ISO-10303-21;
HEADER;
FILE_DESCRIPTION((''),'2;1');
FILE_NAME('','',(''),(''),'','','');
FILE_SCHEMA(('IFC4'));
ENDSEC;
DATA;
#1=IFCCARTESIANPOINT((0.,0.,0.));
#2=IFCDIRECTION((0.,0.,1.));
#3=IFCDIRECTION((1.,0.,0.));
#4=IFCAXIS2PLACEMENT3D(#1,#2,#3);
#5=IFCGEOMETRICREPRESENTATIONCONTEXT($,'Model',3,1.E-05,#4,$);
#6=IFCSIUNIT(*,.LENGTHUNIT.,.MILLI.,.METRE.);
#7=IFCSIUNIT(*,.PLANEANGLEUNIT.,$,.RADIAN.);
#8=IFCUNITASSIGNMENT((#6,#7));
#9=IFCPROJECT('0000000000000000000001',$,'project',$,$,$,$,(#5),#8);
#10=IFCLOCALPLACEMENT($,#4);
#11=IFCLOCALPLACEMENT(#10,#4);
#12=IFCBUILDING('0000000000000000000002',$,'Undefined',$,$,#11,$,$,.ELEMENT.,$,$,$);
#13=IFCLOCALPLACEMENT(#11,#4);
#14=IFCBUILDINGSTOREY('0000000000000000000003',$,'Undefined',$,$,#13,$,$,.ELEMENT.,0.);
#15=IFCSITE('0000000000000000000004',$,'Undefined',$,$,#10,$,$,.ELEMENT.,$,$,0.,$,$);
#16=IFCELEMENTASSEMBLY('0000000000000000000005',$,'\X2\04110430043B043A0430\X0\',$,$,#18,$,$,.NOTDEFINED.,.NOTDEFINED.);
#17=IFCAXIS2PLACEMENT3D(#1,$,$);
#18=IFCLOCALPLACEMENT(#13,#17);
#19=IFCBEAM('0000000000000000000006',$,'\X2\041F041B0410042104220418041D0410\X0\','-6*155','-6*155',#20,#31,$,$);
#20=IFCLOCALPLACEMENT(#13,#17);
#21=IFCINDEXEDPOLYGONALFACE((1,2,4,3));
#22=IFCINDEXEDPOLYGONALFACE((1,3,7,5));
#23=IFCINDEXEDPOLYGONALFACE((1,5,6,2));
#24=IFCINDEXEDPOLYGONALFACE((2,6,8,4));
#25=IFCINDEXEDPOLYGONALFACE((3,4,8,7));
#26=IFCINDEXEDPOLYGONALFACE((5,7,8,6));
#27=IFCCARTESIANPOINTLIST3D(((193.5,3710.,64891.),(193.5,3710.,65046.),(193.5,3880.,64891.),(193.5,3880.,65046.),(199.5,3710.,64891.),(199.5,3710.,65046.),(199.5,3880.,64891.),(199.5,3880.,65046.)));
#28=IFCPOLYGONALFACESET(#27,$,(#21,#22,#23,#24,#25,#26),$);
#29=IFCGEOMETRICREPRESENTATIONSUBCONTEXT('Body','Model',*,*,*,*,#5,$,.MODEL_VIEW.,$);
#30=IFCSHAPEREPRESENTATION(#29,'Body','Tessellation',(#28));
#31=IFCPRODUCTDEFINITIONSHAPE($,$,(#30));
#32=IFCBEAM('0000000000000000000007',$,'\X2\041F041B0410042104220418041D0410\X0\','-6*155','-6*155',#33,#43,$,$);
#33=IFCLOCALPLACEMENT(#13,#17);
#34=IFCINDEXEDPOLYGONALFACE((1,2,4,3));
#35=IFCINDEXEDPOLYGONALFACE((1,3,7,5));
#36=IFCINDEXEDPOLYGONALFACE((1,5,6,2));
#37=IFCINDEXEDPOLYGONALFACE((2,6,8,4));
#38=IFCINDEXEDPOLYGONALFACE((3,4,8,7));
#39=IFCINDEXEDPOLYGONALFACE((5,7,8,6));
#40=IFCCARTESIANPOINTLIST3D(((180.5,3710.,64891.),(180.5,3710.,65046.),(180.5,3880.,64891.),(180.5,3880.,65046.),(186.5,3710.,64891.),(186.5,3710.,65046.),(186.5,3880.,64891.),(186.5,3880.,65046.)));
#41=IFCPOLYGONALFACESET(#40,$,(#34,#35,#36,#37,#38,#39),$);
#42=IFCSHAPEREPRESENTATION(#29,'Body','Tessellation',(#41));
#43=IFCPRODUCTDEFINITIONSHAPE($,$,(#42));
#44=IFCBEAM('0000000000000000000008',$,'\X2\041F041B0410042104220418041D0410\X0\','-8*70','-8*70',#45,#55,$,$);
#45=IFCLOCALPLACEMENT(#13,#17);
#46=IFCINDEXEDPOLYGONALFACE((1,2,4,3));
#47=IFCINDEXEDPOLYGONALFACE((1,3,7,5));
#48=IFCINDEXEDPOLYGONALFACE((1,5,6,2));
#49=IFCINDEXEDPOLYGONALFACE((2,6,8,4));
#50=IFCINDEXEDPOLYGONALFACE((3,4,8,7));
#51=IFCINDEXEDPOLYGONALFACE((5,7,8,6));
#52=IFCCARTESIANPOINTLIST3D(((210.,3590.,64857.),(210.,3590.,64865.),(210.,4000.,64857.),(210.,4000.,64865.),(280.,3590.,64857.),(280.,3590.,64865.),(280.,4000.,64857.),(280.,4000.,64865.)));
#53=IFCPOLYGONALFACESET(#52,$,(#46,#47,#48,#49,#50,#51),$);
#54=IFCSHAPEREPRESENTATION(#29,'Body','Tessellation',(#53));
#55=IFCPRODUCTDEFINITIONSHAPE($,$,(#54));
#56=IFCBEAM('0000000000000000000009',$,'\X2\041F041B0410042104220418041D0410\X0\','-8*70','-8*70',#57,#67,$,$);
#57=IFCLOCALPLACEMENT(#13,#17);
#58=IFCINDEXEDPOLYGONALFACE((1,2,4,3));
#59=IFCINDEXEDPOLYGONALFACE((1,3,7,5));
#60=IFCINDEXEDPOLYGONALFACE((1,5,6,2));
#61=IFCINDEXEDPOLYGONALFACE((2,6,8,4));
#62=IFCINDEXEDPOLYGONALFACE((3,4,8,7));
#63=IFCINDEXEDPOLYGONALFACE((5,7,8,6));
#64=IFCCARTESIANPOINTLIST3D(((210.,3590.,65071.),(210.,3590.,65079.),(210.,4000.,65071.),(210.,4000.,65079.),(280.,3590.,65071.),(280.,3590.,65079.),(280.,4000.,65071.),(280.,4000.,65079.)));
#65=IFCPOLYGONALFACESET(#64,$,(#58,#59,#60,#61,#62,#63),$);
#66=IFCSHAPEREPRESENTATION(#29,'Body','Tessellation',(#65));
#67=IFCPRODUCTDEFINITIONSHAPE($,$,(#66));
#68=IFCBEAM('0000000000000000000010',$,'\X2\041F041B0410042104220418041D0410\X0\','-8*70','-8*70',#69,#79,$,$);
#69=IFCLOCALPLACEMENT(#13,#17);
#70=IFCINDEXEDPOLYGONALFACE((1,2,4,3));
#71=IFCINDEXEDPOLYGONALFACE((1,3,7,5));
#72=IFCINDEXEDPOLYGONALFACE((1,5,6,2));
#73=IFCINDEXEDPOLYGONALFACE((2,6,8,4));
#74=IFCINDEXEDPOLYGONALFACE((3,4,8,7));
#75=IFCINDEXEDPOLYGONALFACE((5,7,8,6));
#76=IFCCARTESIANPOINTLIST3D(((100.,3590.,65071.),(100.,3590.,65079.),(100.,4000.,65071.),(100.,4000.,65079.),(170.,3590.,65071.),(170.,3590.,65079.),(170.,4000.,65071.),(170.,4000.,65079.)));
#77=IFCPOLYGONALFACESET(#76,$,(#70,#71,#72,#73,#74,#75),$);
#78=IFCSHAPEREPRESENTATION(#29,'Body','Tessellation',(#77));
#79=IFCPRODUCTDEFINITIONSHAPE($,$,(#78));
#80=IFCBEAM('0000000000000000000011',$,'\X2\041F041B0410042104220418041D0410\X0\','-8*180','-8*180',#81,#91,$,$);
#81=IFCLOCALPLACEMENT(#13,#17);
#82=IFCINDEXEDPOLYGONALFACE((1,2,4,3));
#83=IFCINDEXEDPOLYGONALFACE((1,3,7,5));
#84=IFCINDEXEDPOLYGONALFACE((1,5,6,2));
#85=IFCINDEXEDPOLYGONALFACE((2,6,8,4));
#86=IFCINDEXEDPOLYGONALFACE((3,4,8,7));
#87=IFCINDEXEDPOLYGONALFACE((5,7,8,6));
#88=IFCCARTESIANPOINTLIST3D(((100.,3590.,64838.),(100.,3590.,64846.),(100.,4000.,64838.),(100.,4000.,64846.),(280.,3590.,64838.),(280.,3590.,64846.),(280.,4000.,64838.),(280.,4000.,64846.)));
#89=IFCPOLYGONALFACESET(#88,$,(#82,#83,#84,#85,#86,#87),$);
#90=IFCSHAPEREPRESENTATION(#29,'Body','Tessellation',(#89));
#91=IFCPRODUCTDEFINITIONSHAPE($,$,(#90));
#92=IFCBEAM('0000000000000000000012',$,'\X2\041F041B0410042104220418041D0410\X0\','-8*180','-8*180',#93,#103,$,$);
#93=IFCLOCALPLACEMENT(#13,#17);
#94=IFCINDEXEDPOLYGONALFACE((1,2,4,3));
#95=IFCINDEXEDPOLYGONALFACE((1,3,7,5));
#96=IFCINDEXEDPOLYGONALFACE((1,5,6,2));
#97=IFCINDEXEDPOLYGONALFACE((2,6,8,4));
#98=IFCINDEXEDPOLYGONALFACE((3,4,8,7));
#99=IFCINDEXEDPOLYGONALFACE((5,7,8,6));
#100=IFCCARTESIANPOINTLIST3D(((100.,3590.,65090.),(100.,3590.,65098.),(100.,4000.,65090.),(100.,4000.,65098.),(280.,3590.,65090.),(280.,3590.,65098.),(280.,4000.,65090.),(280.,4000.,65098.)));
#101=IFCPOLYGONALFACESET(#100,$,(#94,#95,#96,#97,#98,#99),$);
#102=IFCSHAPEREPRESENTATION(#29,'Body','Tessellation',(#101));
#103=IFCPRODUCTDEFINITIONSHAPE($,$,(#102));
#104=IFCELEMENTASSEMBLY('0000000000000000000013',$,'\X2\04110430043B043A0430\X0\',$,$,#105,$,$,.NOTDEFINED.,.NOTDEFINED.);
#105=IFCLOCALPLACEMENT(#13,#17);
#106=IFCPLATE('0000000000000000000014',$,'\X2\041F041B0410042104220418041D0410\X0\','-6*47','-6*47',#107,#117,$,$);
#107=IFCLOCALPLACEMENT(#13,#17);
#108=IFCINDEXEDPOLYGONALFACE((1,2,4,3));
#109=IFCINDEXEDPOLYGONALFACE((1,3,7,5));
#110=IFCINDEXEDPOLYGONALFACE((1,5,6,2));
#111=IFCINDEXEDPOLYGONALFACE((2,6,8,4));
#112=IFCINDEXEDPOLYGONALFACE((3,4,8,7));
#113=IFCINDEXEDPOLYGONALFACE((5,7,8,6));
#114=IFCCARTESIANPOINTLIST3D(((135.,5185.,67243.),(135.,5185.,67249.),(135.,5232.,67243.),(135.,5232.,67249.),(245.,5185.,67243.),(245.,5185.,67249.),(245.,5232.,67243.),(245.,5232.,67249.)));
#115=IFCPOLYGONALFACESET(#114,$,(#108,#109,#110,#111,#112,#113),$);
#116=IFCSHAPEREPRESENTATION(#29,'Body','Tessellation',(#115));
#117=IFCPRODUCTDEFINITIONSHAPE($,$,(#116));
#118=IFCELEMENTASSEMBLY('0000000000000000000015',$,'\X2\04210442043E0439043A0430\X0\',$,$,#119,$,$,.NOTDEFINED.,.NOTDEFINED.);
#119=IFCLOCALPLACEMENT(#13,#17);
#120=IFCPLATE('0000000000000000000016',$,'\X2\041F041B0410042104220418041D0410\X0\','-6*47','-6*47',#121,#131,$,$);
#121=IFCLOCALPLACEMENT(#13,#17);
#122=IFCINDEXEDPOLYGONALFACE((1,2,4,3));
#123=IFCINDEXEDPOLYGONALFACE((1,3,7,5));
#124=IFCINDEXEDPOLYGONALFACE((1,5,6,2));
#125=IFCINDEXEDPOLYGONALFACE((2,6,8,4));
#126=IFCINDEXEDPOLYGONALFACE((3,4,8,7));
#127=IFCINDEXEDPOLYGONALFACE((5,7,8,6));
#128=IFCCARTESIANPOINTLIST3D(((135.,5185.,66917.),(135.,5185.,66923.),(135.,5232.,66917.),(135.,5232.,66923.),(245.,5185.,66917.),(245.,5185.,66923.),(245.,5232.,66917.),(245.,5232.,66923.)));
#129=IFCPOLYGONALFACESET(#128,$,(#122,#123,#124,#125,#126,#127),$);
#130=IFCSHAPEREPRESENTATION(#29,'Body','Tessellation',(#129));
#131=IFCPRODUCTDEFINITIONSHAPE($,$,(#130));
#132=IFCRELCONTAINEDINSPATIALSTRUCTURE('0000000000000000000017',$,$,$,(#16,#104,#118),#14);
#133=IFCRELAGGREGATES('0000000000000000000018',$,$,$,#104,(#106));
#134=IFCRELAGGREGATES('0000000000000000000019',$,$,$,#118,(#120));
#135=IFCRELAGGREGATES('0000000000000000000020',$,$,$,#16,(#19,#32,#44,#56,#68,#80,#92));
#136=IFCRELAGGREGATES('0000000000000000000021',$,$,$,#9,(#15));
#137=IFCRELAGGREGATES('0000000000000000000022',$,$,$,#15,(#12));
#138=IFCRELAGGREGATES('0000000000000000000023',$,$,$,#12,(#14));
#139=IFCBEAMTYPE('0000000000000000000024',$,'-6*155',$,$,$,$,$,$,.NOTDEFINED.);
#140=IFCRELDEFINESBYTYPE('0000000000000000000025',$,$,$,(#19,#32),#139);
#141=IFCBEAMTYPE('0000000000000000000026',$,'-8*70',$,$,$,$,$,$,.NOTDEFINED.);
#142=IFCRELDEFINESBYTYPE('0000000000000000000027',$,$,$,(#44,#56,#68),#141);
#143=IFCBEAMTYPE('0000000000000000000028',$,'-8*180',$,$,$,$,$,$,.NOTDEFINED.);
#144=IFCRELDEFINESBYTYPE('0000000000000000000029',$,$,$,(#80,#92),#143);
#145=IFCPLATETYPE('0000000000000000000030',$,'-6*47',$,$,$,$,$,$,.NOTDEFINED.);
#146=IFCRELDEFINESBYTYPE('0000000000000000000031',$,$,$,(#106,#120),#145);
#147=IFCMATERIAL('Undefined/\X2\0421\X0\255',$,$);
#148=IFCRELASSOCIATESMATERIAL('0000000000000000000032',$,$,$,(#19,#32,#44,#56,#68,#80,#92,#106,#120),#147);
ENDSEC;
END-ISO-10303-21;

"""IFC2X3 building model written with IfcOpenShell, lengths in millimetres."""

from ifc_helpers import new_model, si_unit, frame, origin_with_axes, origin_2d_with_axis, place, context, subcontext, project, spatial, polyline, rectangle, outline, extrude, boolean, material, type_object, element, aggregate, save


model = new_model("IFC2X3")

# Units and contexts
model_context = context("Model", 3, precision=1e-05, world=origin_with_axes())
body_context = subcontext(model_context, "Body", "Model", "MODEL_VIEW")
ifc_project = project(units=[si_unit("LENGTHUNIT", "METRE", prefix="MILLI"), si_unit("PLANEANGLEUNIT", "RADIAN")], contexts=[model_context])

# Site, building, storey
site_placement = place(None, origin_with_axes())
site = spatial("IfcSite", under=ifc_project, at=site_placement, Name="Undefined", CompositionType="ELEMENT", RefElevation=0.0)
building_placement = place(site_placement, origin_with_axes())
building = spatial("IfcBuilding", under=site, at=building_placement, Name="Undefined", CompositionType="ELEMENT")
storey_placement = place(building_placement, origin_with_axes())
storey = spatial("IfcBuildingStorey", under=building, at=storey_placement, Name="Undefined", CompositionType="ELEMENT", Elevation=0.0)

# Element assembly, beams
assembly_1_placement = place(storey_placement, origin_with_axes())
assembly_1 = element("IfcElementAssembly", 1, at=assembly_1_placement, inside=storey, Name="Балка", AssemblyPlace="NOTDEFINED", PredefinedType="NOTDEFINED")
ifc_material_1 = material(Name="Undefined/С255")
beam_type_1 = type_object("IfcBeamType", Name="-6*155", PredefinedType="NOTDEFINED")
beam_1_placement = place(assembly_1_placement, frame((196.5, 3880.0, 64968.5), z_axis=(0.0, 0.0, 1.0), x_axis=(0.0, -1.0, 0.0)))
beam_1 = element("IfcBeam", 2, at=beam_1_placement, type_object=beam_type_1, material=ifc_material_1, Name="ПЛАСТИНА", Description="-6*155", ObjectType="-6*155", context=body_context, shape_type="SweptSolid", body=[
    extrude(rectangle(XDim=6.0, YDim=155.0, at=origin_2d_with_axis()), frame((170.0, 0.0, 0.0), z_axis=(-1.0, 0.0, 0.0), x_axis=(0.0, -1.0, 0.0)), (0.0, 0.0, 1.0), 170.0),
])
beam_2_placement = place(assembly_1_placement, frame((183.5, 3880.0, 64968.5), z_axis=(0.0, 0.0, 1.0), x_axis=(0.0, -1.0, 0.0)))
beam_2 = element("IfcBeam", 3, at=beam_2_placement, type_object=beam_type_1, material=ifc_material_1, Name="ПЛАСТИНА", Description="-6*155", ObjectType="-6*155", context=body_context, shape_type="SweptSolid", body=[
    extrude(rectangle(XDim=6.0, YDim=155.0, at=origin_2d_with_axis()), frame((170.0, 0.0, 0.0), z_axis=(-1.0, 0.0, 0.0), x_axis=(0.0, -1.0, 0.0)), (0.0, 0.0, 1.0), 170.0),
])
beam_type_2 = type_object("IfcBeamType", Name="-8*70", PredefinedType="NOTDEFINED")
beam_3_placement = place(assembly_1_placement, frame((245.0, 3590.0, 64861.0), z_axis=(-1.0, 0.0, 0.0), x_axis=(0.0, 1.0, 0.0)))
beam_3 = element("IfcBeam", 4, at=beam_3_placement, type_object=beam_type_2, material=ifc_material_1, Name="ПЛАСТИНА", Description="-8*70", ObjectType="-8*70", context=body_context, shape_type="SweptSolid", body=[
    extrude(rectangle(XDim=8.0, YDim=70.0, at=origin_2d_with_axis()), frame((410.0, 0.0, 0.0), z_axis=(-1.0, 0.0, 0.0), x_axis=(0.0, -1.0, 0.0)), (0.0, 0.0, 1.0), 410.0),
])
beam_4_placement = place(assembly_1_placement, frame((245.0, 3590.0, 65075.0), z_axis=(-1.0, 0.0, 0.0), x_axis=(0.0, 1.0, 0.0)))
beam_4 = element("IfcBeam", 5, at=beam_4_placement, type_object=beam_type_2, material=ifc_material_1, Name="ПЛАСТИНА", Description="-8*70", ObjectType="-8*70", context=body_context, shape_type="SweptSolid", body=[
    extrude(rectangle(XDim=8.0, YDim=70.0, at=origin_2d_with_axis()), frame((410.0, 0.0, 0.0), z_axis=(-1.0, 0.0, 0.0), x_axis=(0.0, -1.0, 0.0)), (0.0, 0.0, 1.0), 410.0),
])
beam_5_placement = place(assembly_1_placement, frame((135.0, 3590.0, 65075.0), z_axis=(-1.0, 0.0, 0.0), x_axis=(0.0, 1.0, 0.0)))
beam_5 = element("IfcBeam", 6, at=beam_5_placement, type_object=beam_type_2, material=ifc_material_1, Name="ПЛАСТИНА", Description="-8*70", ObjectType="-8*70", context=body_context, shape_type="SweptSolid", body=[
    extrude(rectangle(XDim=8.0, YDim=70.0, at=origin_2d_with_axis()), frame((410.0, 0.0, 0.0), z_axis=(-1.0, 0.0, 0.0), x_axis=(0.0, -1.0, 0.0)), (0.0, 0.0, 1.0), 410.0),
])
beam_type_3 = type_object("IfcBeamType", Name="-8*180", PredefinedType="NOTDEFINED")
beam_6_placement = place(assembly_1_placement, frame((190.0, 4000.0, 64842.0), z_axis=(-1.0, 0.0, 0.0), x_axis=(0.0, -1.0, 0.0)))
beam_6 = element("IfcBeam", 7, at=beam_6_placement, type_object=beam_type_3, material=ifc_material_1, Name="ПЛАСТИНА", Description="-8*180", ObjectType="-8*180", context=body_context, shape_type="SweptSolid", body=[
    extrude(rectangle(XDim=8.0, YDim=180.0, at=origin_2d_with_axis()), frame((410.0, 0.0, 0.0), z_axis=(-1.0, 0.0, 0.0), x_axis=(0.0, -1.0, 0.0)), (0.0, 0.0, 1.0), 410.0),
])
beam_7_placement = place(assembly_1_placement, frame((190.0, 4000.0, 65094.0), z_axis=(-1.0, 0.0, 0.0), x_axis=(0.0, -1.0, 0.0)))
beam_7 = element("IfcBeam", 8, at=beam_7_placement, type_object=beam_type_3, material=ifc_material_1, Name="ПЛАСТИНА", Description="-8*180", ObjectType="-8*180", context=body_context, shape_type="SweptSolid", body=[
    extrude(rectangle(XDim=8.0, YDim=180.0, at=origin_2d_with_axis()), frame((410.0, 0.0, 0.0), z_axis=(-1.0, 0.0, 0.0), x_axis=(0.0, -1.0, 0.0)), (0.0, 0.0, 1.0), 410.0),
])

# Element assembly, plate
assembly_2_placement = place(storey_placement, origin_with_axes())
assembly_2 = element("IfcElementAssembly", 9, at=assembly_2_placement, inside=storey, Name="Балка", AssemblyPlace="NOTDEFINED", PredefinedType="NOTDEFINED")
plate_type = type_object("IfcPlateType", Name="-6*47", PredefinedType="NOTDEFINED")
plate_1_placement = place(assembly_2_placement, frame((245.0, 5185.0, 67246.0), z_axis=(0.0, 0.0, -1.0), x_axis=(-1.0, 0.0, 0.0)))
plate_1 = element("IfcPlate", 10, at=plate_1_placement, type_object=plate_type, material=ifc_material_1, Name="ПЛАСТИНА", Description="-6*47", ObjectType="-6*47", context=body_context, shape_type="CSG", body=[
    boolean("DIFFERENCE", extrude(outline(polyline([(0.0, 0.0), (110.0, 0.0), (110.0, 110.0), (0.0, 110.0), (0.0, 0.0)])), frame((0.0, 0.0, -3.0), z_axis=(0.0, 0.0, 1.0), x_axis=(1.0, 0.0, 0.0)), (0.0, 0.0, 1.0), 6.0), extrude(rectangle(XDim=26.0, YDim=130.0, at=origin_2d_with_axis()), frame((55.0, 47.0, 0.0), z_axis=(0.0, 1.0, 0.0), x_axis=(0.0, 0.0, -1.0)), (0.0, 0.0, 1.0), 66.0)),
])
aggregate(assembly_2, [plate_1])

# Element assembly, plate
assembly_3_placement = place(storey_placement, origin_with_axes())
assembly_3 = element("IfcElementAssembly", 11, at=assembly_3_placement, inside=storey, Name="Стойка", AssemblyPlace="NOTDEFINED", PredefinedType="NOTDEFINED")
plate_2_placement = place(assembly_3_placement, frame((135.0, 5185.0, 66920.0), z_axis=(0.0, 0.0, 1.0), x_axis=(1.0, 0.0, 0.0)))
plate_2 = element("IfcPlate", 12, at=plate_2_placement, type_object=plate_type, material=ifc_material_1, Name="ПЛАСТИНА", Description="-6*47", ObjectType="-6*47", context=body_context, shape_type="CSG", body=[
    boolean("DIFFERENCE", extrude(outline(polyline([(0.0, 0.0), (110.0, 0.0), (110.0, 110.0), (0.0, 110.0), (0.0, 0.0)])), frame((0.0, 0.0, -3.0), z_axis=(0.0, 0.0, 1.0), x_axis=(1.0, 0.0, 0.0)), (0.0, 0.0, 1.0), 6.0), extrude(rectangle(XDim=26.0, YDim=130.0, at=origin_2d_with_axis()), frame((55.0, 47.0, 0.0), z_axis=(0.0, 1.0, 0.0), x_axis=(0.0, 0.0, -1.0)), (0.0, 0.0, 1.0), 66.0)),
])
aggregate(assembly_3, [plate_2])

aggregate(assembly_1, [beam_1, beam_2, beam_3, beam_4, beam_5, beam_6, beam_7])

save(model, "model.ifc")
